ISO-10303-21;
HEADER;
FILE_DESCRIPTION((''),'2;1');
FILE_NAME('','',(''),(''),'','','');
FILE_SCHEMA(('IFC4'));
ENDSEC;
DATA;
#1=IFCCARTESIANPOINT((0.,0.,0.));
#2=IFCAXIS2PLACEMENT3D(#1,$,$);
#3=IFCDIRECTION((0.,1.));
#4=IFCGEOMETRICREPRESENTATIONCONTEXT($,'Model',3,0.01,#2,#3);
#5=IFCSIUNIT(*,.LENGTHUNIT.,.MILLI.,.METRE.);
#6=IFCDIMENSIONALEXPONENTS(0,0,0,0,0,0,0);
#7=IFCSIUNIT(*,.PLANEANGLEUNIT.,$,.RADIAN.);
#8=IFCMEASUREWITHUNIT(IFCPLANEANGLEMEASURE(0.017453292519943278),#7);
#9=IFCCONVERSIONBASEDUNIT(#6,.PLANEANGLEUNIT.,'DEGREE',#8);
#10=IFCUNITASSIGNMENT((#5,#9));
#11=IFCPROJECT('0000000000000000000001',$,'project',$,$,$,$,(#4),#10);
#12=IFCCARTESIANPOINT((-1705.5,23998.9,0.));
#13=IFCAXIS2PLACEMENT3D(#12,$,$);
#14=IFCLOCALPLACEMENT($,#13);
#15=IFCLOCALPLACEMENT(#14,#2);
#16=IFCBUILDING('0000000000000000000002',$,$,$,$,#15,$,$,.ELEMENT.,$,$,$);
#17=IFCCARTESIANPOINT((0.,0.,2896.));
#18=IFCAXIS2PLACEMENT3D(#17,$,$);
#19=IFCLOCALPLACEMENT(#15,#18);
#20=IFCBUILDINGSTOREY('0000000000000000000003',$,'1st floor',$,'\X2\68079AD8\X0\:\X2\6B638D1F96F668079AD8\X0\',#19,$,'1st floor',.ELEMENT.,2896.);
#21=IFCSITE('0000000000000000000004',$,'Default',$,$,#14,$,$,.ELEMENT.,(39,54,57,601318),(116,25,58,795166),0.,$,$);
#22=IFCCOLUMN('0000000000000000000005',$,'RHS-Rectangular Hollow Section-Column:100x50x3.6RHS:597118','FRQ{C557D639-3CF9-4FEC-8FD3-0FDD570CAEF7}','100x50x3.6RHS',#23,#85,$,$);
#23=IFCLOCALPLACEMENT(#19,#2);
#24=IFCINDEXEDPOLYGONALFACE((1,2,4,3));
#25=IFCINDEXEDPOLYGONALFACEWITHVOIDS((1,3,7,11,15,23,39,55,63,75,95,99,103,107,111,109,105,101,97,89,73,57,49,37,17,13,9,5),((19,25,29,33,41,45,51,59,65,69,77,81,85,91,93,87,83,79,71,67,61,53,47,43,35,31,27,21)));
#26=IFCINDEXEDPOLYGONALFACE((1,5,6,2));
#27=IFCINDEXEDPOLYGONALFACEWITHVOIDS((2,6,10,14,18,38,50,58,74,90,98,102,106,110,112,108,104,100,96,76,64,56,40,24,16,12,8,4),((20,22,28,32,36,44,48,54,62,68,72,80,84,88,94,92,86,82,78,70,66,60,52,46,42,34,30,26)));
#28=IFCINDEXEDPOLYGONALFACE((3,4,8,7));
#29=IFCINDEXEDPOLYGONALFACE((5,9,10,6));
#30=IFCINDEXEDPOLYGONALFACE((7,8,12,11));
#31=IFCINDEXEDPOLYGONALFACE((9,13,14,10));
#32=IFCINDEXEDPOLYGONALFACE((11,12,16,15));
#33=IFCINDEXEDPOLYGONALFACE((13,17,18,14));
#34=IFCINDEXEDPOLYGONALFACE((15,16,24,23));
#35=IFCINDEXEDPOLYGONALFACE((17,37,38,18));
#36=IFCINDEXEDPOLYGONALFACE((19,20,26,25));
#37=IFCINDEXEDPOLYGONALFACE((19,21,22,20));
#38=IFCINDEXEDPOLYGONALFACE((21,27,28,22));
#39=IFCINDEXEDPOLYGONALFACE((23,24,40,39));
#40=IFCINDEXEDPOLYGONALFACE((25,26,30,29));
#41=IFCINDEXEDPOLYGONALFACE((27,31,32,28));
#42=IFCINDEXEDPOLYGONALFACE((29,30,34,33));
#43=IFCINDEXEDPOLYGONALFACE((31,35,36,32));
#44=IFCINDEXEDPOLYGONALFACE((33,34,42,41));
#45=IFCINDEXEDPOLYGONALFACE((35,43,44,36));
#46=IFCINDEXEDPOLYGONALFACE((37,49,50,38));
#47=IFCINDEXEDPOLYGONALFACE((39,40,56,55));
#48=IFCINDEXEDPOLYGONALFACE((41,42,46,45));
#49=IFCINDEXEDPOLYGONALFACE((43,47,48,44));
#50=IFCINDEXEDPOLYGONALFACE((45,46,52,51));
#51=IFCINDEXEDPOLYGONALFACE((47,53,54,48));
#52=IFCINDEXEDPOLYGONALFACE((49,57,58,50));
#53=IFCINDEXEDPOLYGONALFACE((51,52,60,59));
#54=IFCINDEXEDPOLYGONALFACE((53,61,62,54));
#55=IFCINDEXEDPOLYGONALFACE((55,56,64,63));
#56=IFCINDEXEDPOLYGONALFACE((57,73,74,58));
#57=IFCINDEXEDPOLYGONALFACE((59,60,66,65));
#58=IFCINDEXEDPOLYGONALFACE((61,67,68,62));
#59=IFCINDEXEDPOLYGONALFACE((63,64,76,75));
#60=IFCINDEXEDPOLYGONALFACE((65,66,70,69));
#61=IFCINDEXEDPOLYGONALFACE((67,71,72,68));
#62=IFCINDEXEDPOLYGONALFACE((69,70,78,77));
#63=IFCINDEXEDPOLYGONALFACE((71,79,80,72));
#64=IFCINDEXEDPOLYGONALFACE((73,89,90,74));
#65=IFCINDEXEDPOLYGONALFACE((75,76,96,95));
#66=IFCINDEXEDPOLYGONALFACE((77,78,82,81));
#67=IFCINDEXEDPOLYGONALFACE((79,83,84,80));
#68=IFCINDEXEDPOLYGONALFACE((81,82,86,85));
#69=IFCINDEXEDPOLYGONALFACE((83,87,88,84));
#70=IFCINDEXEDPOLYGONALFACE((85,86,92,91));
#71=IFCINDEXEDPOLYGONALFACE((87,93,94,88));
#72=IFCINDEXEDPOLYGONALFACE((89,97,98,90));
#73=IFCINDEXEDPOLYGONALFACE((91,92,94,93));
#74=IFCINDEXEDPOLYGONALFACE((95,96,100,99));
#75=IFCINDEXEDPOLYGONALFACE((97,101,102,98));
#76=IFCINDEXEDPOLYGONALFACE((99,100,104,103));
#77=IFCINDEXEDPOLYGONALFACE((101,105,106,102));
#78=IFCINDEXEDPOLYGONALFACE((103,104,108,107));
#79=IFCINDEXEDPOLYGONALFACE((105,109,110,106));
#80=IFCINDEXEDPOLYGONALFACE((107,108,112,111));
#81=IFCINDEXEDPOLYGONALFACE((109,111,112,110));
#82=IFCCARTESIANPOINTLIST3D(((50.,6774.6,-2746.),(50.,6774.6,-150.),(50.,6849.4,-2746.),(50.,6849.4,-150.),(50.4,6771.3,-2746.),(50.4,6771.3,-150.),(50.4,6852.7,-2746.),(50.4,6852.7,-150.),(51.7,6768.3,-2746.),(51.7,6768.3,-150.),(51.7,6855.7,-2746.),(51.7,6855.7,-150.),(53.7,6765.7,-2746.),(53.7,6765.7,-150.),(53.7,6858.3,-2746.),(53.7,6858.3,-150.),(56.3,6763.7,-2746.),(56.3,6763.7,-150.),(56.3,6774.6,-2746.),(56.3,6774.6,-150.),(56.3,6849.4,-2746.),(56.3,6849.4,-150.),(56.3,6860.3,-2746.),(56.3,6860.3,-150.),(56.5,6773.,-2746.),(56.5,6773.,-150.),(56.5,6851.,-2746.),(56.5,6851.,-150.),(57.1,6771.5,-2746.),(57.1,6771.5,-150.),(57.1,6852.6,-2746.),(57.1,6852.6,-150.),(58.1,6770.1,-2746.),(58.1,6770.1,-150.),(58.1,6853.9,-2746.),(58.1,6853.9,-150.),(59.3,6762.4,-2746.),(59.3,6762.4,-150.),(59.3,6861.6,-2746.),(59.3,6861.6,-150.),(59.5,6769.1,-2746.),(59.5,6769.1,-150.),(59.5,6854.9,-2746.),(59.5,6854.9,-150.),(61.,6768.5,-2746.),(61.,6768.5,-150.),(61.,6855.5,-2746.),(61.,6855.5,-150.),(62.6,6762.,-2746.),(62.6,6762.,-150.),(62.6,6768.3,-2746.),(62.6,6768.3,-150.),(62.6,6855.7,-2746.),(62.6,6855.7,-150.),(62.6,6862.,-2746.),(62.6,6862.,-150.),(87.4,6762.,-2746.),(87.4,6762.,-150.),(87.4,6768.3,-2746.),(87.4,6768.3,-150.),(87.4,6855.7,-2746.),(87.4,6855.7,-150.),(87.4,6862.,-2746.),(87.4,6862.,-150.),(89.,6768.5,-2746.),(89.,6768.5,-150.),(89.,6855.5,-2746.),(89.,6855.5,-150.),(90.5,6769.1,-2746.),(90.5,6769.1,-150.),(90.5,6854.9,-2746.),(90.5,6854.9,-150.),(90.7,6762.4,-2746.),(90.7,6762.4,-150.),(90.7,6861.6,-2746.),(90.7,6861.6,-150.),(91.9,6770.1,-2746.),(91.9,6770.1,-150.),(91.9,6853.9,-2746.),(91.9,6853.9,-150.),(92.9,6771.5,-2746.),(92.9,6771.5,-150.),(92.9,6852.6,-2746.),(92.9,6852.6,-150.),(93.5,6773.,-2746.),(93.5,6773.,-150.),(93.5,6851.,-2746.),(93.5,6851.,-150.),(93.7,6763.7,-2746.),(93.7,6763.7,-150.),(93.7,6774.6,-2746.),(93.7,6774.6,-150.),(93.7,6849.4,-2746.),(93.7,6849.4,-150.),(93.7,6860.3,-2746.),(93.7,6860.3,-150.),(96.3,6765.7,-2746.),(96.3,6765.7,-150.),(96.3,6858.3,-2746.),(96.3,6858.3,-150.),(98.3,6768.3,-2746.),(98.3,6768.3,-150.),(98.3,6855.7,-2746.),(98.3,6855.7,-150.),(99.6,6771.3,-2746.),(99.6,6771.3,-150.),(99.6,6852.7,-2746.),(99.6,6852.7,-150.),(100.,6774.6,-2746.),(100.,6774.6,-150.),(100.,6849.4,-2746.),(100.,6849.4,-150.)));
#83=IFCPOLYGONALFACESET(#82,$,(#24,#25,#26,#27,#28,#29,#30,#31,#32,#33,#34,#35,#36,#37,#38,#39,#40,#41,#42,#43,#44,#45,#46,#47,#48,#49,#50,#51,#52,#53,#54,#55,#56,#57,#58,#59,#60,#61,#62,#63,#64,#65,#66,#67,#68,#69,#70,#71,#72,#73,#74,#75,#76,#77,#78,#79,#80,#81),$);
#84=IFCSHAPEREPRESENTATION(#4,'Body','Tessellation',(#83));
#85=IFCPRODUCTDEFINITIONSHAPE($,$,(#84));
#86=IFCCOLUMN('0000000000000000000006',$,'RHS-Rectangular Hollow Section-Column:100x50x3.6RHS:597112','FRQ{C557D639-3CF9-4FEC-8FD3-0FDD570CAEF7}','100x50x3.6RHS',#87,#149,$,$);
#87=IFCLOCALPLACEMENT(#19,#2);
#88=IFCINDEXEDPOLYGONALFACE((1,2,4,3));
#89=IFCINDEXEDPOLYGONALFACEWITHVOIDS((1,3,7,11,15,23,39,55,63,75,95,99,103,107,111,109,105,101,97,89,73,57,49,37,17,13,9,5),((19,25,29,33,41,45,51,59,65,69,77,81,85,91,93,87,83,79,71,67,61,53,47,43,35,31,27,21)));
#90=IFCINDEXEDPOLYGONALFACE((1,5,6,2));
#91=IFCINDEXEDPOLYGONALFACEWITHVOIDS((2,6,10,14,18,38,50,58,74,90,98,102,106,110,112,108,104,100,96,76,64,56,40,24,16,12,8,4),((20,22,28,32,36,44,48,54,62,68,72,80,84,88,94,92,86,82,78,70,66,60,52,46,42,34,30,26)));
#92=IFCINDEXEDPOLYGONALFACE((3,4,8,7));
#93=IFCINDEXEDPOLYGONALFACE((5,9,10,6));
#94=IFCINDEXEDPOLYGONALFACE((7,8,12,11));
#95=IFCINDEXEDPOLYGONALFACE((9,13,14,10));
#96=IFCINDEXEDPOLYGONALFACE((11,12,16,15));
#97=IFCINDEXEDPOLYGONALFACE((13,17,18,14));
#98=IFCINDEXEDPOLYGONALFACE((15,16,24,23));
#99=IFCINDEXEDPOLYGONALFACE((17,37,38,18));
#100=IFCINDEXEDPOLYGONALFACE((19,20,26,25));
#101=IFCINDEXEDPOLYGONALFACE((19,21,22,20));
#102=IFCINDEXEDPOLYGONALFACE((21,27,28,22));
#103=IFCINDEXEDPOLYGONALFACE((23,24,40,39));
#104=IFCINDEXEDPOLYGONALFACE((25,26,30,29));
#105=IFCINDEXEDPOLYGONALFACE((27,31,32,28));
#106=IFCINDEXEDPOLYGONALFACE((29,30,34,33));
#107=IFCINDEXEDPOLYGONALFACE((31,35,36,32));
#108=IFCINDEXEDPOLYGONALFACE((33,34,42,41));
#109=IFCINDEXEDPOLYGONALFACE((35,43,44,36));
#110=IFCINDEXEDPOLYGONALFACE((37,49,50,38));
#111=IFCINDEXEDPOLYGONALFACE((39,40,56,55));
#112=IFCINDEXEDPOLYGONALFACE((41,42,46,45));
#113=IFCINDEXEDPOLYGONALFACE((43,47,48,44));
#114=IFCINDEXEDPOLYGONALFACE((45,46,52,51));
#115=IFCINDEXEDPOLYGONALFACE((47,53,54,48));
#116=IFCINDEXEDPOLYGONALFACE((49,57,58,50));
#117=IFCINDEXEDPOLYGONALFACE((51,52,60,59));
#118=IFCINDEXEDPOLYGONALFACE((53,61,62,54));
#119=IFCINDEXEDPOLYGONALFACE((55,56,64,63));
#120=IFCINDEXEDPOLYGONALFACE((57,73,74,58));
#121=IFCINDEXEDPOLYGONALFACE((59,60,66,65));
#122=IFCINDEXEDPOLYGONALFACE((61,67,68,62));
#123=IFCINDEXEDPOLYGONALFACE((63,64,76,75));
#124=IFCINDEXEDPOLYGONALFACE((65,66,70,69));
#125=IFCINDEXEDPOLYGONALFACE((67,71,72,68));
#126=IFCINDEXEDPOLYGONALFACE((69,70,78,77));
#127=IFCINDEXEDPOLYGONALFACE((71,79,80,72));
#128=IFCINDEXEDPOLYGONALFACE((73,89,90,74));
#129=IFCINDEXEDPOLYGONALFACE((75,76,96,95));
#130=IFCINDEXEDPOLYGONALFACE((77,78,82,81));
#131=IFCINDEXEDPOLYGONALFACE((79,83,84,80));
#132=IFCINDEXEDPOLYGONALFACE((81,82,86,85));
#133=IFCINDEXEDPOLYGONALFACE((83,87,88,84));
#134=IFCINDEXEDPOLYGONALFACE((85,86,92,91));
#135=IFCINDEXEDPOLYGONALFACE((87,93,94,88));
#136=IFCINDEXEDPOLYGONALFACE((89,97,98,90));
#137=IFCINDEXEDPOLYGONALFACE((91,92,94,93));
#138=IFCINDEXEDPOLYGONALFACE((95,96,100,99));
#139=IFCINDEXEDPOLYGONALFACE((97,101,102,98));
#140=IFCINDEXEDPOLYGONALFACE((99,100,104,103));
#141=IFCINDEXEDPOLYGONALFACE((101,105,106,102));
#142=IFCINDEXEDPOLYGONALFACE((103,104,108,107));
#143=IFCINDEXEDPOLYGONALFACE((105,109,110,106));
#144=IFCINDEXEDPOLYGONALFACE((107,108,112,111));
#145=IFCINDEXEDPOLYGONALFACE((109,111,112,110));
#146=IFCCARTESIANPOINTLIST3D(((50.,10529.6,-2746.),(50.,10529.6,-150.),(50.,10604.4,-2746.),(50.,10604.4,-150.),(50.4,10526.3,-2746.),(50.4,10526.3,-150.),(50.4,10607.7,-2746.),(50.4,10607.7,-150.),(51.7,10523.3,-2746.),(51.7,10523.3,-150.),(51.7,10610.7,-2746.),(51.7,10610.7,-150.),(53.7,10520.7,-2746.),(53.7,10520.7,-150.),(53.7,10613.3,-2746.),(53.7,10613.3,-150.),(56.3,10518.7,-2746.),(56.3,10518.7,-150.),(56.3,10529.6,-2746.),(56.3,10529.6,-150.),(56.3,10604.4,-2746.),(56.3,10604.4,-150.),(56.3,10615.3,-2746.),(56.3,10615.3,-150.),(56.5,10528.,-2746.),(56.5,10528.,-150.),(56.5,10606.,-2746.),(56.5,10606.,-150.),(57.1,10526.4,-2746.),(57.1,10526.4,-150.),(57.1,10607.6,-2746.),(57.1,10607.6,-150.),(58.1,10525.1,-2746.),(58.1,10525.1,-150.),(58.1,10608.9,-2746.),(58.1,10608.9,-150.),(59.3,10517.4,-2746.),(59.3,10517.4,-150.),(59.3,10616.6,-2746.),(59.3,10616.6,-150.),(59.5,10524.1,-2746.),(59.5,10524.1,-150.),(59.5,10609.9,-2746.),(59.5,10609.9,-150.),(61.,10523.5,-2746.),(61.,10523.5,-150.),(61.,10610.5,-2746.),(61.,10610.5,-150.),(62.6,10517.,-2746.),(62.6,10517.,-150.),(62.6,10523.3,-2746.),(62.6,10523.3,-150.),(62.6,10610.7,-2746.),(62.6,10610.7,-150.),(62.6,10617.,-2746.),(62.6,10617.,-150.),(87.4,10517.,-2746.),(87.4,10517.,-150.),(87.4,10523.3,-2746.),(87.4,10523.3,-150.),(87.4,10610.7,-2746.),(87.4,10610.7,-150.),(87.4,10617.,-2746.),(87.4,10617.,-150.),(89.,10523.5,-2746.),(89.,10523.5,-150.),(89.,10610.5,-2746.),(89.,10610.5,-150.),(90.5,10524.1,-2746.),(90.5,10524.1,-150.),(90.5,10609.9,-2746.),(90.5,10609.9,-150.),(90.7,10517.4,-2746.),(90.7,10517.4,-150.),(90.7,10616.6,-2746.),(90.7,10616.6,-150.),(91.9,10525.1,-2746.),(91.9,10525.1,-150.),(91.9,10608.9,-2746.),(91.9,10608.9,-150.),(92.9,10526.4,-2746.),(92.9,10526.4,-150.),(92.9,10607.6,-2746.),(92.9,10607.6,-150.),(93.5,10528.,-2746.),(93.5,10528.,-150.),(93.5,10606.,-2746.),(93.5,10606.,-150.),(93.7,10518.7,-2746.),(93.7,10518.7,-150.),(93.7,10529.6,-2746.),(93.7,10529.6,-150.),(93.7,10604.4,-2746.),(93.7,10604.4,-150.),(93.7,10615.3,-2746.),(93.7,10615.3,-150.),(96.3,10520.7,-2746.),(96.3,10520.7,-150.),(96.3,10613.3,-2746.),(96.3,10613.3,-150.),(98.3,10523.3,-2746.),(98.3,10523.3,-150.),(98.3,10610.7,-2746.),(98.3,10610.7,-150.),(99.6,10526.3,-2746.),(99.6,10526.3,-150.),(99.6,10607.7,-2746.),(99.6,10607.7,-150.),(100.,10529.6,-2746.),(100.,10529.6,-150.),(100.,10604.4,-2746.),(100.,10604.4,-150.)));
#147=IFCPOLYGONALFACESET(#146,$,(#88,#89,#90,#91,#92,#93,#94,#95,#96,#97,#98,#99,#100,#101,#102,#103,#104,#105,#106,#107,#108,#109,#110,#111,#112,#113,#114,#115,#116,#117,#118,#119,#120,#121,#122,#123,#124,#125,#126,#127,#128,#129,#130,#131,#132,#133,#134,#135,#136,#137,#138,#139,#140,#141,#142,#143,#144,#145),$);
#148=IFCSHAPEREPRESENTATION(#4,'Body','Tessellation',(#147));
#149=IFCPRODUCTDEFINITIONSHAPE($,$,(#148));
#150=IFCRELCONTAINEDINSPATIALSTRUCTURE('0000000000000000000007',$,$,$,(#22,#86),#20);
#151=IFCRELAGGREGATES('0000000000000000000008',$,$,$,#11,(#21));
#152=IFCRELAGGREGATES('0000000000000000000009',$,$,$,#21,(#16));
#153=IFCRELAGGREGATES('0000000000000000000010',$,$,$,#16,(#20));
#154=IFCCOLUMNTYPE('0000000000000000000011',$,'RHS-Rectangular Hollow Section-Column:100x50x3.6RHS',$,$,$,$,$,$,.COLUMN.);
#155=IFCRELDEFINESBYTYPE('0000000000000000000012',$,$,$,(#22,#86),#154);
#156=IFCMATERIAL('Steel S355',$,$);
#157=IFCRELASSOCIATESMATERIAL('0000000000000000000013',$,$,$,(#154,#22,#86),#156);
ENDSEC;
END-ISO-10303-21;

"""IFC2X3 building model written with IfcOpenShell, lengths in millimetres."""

from ifc_helpers import new_model, entity, si_unit, converted_unit, point, direction, frame, frame_2d, origin, origin_2d, place, context, project, spatial, circle_curve, line_curve, trimmed, segment, composite_curve, hollow_rectangle, outline, extrude, clip, halfspace, material, type_object, element, save


model = new_model("IFC2X3")

# Units and contexts
model_context = context("Model", 3, precision=0.01, world=origin(), true_north=direction((0.0, 1.0)))
ifc_project = project(units=[si_unit("LENGTHUNIT", "METRE", prefix="MILLI"), converted_unit("PLANEANGLEUNIT", "DEGREE", entity("IfcPlaneAngleMeasure", 0.017453292519943278), si_unit("PLANEANGLEUNIT", "RADIAN"), dimensions=[0, 0, 0, 0, 0, 0, 0])], contexts=[model_context])

# Site, building, storey
site_placement = place(None, frame((-1705.5, 23998.9, 0.0)))
site = spatial("IfcSite", under=ifc_project, at=site_placement, Name="Default", CompositionType="ELEMENT", RefLatitude=(39, 54, 57, 601318), RefLongitude=(116, 25, 58, 795166), RefElevation=0.0)
building_placement = place(site_placement, origin())
building = spatial("IfcBuilding", under=site, at=building_placement, CompositionType="ELEMENT")
storey_placement = place(building_placement, frame((0.0, 0.0, 2896.0)))
storey = spatial("IfcBuildingStorey", under=building, at=storey_placement, Name="1st floor", ObjectType="标高:正负零标高", LongName="1st floor", CompositionType="ELEMENT", Elevation=2896.0)

# Columns, openings
ifc_material_1 = material(Name="Steel S355")
column_type_1 = type_object("IfcColumnType", Name="RHS-Rectangular Hollow Section-Column:100x50x3.6RHS", PredefinedType="COLUMN", material=ifc_material_1)
column_1_placement = place(storey_placement, frame((75.0, 6812.0, -19.1)))
column_1 = element("IfcColumn", 1, at=column_1_placement, inside=storey, type_object=column_type_1, material=ifc_material_1, Name="RHS-Rectangular Hollow Section-Column:100x50x3.6RHS:597118", Description="FRQ{C557D639-3CF9-4FEC-8FD3-0FDD570CAEF7}", ObjectType="100x50x3.6RHS", context=model_context, shape_type="Clipping", body=[
    clip(clip(extrude(hollow_rectangle(XDim=50.0, YDim=100.0, WallThickness=6.3, InnerFilletRadius=6.3, OuterFilletRadius=12.6, at=origin_2d()), origin(), (0.0, 0.0, -1.0), 2782.8), halfspace(frame((-75.0, -6812.0, -2726.9), z_axis=(0.0, 0.0, 1.0), x_axis=(1.0, 0.0, 0.0)), True)), halfspace(frame((-75.0, -6812.0, -55.9), z_axis=(0.0, 0.0, -1.0), x_axis=(-1.0, 0.0, 0.0)), True)),
])
opening_1_placement = place(column_1_placement, frame((0.0, -150.1, -130.9), z_axis=(0.0, 1.0, 0.0), x_axis=(-1.0, 0.0, 0.0)))
element("IfcOpeningElement", 2, at=opening_1_placement, cuts=column_1, ObjectType="Opening", context=model_context, shape_type="SweptSolid", body=[
    extrude(outline(composite_curve([segment(trimmed(circle_curve(frame_2d((43.0, 32.0), x_axis=(1.0, 0.0)), 32.0), [point((43.0, 0.0))], [point((75.0, 32.0))], True, "CARTESIAN"), True, "CONTINUOUS"), segment(trimmed(line_curve((75.0, 32.0), (0.0, 1.0), 86.0), [point((75.0, 32.0))], [point((75.0, 118.0))], True, "CARTESIAN"), True, "CONTINUOUS"), segment(trimmed(circle_curve(frame_2d((43.0, 118.0), x_axis=(1.0, 0.0)), 32.0), [point((75.0, 118.0))], [point((43.0, 150.0))], True, "CARTESIAN"), True, "CONTINUOUS"), segment(trimmed(line_curve((43.0, 150.0), (-1.0, 0.0), 86.0), [point((43.0, 150.0))], [point((-43.0, 150.0))], True, "CARTESIAN"), True, "CONTINUOUS"), segment(trimmed(circle_curve(frame_2d((-43.0, 118.0), x_axis=(1.0, 0.0)), 32.0), [point((-43.0, 150.0))], [point((-75.0, 118.0))], True, "CARTESIAN"), True, "CONTINUOUS"), segment(trimmed(line_curve((-75.0, 118.0), (0.0, -1.0), 86.0), [point((-75.0, 118.0))], [point((-75.0, 32.0))], True, "CARTESIAN"), True, "CONTINUOUS"), segment(trimmed(circle_curve(frame_2d((-43.0, 32.0), x_axis=(1.0, 0.0)), 32.0), [point((-75.0, 32.0))], [point((-43.0, 0.0))], True, "CARTESIAN"), True, "CONTINUOUS"), segment(trimmed(line_curve((-43.0, 0.0), (1.0, 0.0), 86.0), [point((-43.0, 0.0))], [point((43.0, 0.0))], True, "CARTESIAN"), True, "CONTINUOUS")], self_intersect="UNKNOWN")), origin(), (0.0, 0.0, 1.0), 300.2),
])
column_2_placement = place(storey_placement, frame((75.0, 10567.0, -19.1)))
column_2 = element("IfcColumn", 3, at=column_2_placement, inside=storey, type_object=column_type_1, material=ifc_material_1, Name="RHS-Rectangular Hollow Section-Column:100x50x3.6RHS:597112", Description="FRQ{C557D639-3CF9-4FEC-8FD3-0FDD570CAEF7}", ObjectType="100x50x3.6RHS", context=model_context, shape_type="Clipping", body=[
    clip(clip(extrude(hollow_rectangle(XDim=50.0, YDim=100.0, WallThickness=6.3, InnerFilletRadius=6.3, OuterFilletRadius=12.6, at=origin_2d()), origin(), (0.0, 0.0, -1.0), 2782.8), halfspace(frame((-75.0, -10567.0, -55.9), z_axis=(0.0, 0.0, -1.0), x_axis=(-1.0, 0.0, 0.0)), True)), halfspace(frame((-75.0, -10567.0, -2726.9), z_axis=(0.0, 0.0, 1.0), x_axis=(1.0, 0.0, 0.0)), True)),
])
opening_2_placement = place(column_2_placement, frame((0.0, -150.1, -130.9), z_axis=(0.0, 1.0, 0.0), x_axis=(-1.0, 0.0, 0.0)))
element("IfcOpeningElement", 4, at=opening_2_placement, cuts=column_2, ObjectType="Opening", context=model_context, shape_type="SweptSolid", body=[
    extrude(outline(composite_curve([segment(trimmed(circle_curve(frame_2d((43.0, 32.0), x_axis=(1.0, 0.0)), 32.0), [point((43.0, 0.0))], [point((75.0, 32.0))], True, "CARTESIAN"), True, "CONTINUOUS"), segment(trimmed(line_curve((75.0, 32.0), (0.0, 1.0), 86.0), [point((75.0, 32.0))], [point((75.0, 118.0))], True, "CARTESIAN"), True, "CONTINUOUS"), segment(trimmed(circle_curve(frame_2d((43.0, 118.0), x_axis=(1.0, 0.0)), 32.0), [point((75.0, 118.0))], [point((43.0, 150.0))], True, "CARTESIAN"), True, "CONTINUOUS"), segment(trimmed(line_curve((43.0, 150.0), (-1.0, 0.0), 86.0), [point((43.0, 150.0))], [point((-43.0, 150.0))], True, "CARTESIAN"), True, "CONTINUOUS"), segment(trimmed(circle_curve(frame_2d((-43.0, 118.0), x_axis=(1.0, 0.0)), 32.0), [point((-43.0, 150.0))], [point((-75.0, 118.0))], True, "CARTESIAN"), True, "CONTINUOUS"), segment(trimmed(line_curve((-75.0, 118.0), (0.0, -1.0), 86.0), [point((-75.0, 118.0))], [point((-75.0, 32.0))], True, "CARTESIAN"), True, "CONTINUOUS"), segment(trimmed(circle_curve(frame_2d((-43.0, 32.0), x_axis=(1.0, 0.0)), 32.0), [point((-75.0, 32.0))], [point((-43.0, 0.0))], True, "CARTESIAN"), True, "CONTINUOUS"), segment(trimmed(line_curve((-43.0, 0.0), (1.0, 0.0), 86.0), [point((-43.0, 0.0))], [point((43.0, 0.0))], True, "CARTESIAN"), True, "CONTINUOUS")], self_intersect="UNKNOWN")), origin(), (0.0, 0.0, 1.0), 300.2),
])

save(model, "model.ifc")
